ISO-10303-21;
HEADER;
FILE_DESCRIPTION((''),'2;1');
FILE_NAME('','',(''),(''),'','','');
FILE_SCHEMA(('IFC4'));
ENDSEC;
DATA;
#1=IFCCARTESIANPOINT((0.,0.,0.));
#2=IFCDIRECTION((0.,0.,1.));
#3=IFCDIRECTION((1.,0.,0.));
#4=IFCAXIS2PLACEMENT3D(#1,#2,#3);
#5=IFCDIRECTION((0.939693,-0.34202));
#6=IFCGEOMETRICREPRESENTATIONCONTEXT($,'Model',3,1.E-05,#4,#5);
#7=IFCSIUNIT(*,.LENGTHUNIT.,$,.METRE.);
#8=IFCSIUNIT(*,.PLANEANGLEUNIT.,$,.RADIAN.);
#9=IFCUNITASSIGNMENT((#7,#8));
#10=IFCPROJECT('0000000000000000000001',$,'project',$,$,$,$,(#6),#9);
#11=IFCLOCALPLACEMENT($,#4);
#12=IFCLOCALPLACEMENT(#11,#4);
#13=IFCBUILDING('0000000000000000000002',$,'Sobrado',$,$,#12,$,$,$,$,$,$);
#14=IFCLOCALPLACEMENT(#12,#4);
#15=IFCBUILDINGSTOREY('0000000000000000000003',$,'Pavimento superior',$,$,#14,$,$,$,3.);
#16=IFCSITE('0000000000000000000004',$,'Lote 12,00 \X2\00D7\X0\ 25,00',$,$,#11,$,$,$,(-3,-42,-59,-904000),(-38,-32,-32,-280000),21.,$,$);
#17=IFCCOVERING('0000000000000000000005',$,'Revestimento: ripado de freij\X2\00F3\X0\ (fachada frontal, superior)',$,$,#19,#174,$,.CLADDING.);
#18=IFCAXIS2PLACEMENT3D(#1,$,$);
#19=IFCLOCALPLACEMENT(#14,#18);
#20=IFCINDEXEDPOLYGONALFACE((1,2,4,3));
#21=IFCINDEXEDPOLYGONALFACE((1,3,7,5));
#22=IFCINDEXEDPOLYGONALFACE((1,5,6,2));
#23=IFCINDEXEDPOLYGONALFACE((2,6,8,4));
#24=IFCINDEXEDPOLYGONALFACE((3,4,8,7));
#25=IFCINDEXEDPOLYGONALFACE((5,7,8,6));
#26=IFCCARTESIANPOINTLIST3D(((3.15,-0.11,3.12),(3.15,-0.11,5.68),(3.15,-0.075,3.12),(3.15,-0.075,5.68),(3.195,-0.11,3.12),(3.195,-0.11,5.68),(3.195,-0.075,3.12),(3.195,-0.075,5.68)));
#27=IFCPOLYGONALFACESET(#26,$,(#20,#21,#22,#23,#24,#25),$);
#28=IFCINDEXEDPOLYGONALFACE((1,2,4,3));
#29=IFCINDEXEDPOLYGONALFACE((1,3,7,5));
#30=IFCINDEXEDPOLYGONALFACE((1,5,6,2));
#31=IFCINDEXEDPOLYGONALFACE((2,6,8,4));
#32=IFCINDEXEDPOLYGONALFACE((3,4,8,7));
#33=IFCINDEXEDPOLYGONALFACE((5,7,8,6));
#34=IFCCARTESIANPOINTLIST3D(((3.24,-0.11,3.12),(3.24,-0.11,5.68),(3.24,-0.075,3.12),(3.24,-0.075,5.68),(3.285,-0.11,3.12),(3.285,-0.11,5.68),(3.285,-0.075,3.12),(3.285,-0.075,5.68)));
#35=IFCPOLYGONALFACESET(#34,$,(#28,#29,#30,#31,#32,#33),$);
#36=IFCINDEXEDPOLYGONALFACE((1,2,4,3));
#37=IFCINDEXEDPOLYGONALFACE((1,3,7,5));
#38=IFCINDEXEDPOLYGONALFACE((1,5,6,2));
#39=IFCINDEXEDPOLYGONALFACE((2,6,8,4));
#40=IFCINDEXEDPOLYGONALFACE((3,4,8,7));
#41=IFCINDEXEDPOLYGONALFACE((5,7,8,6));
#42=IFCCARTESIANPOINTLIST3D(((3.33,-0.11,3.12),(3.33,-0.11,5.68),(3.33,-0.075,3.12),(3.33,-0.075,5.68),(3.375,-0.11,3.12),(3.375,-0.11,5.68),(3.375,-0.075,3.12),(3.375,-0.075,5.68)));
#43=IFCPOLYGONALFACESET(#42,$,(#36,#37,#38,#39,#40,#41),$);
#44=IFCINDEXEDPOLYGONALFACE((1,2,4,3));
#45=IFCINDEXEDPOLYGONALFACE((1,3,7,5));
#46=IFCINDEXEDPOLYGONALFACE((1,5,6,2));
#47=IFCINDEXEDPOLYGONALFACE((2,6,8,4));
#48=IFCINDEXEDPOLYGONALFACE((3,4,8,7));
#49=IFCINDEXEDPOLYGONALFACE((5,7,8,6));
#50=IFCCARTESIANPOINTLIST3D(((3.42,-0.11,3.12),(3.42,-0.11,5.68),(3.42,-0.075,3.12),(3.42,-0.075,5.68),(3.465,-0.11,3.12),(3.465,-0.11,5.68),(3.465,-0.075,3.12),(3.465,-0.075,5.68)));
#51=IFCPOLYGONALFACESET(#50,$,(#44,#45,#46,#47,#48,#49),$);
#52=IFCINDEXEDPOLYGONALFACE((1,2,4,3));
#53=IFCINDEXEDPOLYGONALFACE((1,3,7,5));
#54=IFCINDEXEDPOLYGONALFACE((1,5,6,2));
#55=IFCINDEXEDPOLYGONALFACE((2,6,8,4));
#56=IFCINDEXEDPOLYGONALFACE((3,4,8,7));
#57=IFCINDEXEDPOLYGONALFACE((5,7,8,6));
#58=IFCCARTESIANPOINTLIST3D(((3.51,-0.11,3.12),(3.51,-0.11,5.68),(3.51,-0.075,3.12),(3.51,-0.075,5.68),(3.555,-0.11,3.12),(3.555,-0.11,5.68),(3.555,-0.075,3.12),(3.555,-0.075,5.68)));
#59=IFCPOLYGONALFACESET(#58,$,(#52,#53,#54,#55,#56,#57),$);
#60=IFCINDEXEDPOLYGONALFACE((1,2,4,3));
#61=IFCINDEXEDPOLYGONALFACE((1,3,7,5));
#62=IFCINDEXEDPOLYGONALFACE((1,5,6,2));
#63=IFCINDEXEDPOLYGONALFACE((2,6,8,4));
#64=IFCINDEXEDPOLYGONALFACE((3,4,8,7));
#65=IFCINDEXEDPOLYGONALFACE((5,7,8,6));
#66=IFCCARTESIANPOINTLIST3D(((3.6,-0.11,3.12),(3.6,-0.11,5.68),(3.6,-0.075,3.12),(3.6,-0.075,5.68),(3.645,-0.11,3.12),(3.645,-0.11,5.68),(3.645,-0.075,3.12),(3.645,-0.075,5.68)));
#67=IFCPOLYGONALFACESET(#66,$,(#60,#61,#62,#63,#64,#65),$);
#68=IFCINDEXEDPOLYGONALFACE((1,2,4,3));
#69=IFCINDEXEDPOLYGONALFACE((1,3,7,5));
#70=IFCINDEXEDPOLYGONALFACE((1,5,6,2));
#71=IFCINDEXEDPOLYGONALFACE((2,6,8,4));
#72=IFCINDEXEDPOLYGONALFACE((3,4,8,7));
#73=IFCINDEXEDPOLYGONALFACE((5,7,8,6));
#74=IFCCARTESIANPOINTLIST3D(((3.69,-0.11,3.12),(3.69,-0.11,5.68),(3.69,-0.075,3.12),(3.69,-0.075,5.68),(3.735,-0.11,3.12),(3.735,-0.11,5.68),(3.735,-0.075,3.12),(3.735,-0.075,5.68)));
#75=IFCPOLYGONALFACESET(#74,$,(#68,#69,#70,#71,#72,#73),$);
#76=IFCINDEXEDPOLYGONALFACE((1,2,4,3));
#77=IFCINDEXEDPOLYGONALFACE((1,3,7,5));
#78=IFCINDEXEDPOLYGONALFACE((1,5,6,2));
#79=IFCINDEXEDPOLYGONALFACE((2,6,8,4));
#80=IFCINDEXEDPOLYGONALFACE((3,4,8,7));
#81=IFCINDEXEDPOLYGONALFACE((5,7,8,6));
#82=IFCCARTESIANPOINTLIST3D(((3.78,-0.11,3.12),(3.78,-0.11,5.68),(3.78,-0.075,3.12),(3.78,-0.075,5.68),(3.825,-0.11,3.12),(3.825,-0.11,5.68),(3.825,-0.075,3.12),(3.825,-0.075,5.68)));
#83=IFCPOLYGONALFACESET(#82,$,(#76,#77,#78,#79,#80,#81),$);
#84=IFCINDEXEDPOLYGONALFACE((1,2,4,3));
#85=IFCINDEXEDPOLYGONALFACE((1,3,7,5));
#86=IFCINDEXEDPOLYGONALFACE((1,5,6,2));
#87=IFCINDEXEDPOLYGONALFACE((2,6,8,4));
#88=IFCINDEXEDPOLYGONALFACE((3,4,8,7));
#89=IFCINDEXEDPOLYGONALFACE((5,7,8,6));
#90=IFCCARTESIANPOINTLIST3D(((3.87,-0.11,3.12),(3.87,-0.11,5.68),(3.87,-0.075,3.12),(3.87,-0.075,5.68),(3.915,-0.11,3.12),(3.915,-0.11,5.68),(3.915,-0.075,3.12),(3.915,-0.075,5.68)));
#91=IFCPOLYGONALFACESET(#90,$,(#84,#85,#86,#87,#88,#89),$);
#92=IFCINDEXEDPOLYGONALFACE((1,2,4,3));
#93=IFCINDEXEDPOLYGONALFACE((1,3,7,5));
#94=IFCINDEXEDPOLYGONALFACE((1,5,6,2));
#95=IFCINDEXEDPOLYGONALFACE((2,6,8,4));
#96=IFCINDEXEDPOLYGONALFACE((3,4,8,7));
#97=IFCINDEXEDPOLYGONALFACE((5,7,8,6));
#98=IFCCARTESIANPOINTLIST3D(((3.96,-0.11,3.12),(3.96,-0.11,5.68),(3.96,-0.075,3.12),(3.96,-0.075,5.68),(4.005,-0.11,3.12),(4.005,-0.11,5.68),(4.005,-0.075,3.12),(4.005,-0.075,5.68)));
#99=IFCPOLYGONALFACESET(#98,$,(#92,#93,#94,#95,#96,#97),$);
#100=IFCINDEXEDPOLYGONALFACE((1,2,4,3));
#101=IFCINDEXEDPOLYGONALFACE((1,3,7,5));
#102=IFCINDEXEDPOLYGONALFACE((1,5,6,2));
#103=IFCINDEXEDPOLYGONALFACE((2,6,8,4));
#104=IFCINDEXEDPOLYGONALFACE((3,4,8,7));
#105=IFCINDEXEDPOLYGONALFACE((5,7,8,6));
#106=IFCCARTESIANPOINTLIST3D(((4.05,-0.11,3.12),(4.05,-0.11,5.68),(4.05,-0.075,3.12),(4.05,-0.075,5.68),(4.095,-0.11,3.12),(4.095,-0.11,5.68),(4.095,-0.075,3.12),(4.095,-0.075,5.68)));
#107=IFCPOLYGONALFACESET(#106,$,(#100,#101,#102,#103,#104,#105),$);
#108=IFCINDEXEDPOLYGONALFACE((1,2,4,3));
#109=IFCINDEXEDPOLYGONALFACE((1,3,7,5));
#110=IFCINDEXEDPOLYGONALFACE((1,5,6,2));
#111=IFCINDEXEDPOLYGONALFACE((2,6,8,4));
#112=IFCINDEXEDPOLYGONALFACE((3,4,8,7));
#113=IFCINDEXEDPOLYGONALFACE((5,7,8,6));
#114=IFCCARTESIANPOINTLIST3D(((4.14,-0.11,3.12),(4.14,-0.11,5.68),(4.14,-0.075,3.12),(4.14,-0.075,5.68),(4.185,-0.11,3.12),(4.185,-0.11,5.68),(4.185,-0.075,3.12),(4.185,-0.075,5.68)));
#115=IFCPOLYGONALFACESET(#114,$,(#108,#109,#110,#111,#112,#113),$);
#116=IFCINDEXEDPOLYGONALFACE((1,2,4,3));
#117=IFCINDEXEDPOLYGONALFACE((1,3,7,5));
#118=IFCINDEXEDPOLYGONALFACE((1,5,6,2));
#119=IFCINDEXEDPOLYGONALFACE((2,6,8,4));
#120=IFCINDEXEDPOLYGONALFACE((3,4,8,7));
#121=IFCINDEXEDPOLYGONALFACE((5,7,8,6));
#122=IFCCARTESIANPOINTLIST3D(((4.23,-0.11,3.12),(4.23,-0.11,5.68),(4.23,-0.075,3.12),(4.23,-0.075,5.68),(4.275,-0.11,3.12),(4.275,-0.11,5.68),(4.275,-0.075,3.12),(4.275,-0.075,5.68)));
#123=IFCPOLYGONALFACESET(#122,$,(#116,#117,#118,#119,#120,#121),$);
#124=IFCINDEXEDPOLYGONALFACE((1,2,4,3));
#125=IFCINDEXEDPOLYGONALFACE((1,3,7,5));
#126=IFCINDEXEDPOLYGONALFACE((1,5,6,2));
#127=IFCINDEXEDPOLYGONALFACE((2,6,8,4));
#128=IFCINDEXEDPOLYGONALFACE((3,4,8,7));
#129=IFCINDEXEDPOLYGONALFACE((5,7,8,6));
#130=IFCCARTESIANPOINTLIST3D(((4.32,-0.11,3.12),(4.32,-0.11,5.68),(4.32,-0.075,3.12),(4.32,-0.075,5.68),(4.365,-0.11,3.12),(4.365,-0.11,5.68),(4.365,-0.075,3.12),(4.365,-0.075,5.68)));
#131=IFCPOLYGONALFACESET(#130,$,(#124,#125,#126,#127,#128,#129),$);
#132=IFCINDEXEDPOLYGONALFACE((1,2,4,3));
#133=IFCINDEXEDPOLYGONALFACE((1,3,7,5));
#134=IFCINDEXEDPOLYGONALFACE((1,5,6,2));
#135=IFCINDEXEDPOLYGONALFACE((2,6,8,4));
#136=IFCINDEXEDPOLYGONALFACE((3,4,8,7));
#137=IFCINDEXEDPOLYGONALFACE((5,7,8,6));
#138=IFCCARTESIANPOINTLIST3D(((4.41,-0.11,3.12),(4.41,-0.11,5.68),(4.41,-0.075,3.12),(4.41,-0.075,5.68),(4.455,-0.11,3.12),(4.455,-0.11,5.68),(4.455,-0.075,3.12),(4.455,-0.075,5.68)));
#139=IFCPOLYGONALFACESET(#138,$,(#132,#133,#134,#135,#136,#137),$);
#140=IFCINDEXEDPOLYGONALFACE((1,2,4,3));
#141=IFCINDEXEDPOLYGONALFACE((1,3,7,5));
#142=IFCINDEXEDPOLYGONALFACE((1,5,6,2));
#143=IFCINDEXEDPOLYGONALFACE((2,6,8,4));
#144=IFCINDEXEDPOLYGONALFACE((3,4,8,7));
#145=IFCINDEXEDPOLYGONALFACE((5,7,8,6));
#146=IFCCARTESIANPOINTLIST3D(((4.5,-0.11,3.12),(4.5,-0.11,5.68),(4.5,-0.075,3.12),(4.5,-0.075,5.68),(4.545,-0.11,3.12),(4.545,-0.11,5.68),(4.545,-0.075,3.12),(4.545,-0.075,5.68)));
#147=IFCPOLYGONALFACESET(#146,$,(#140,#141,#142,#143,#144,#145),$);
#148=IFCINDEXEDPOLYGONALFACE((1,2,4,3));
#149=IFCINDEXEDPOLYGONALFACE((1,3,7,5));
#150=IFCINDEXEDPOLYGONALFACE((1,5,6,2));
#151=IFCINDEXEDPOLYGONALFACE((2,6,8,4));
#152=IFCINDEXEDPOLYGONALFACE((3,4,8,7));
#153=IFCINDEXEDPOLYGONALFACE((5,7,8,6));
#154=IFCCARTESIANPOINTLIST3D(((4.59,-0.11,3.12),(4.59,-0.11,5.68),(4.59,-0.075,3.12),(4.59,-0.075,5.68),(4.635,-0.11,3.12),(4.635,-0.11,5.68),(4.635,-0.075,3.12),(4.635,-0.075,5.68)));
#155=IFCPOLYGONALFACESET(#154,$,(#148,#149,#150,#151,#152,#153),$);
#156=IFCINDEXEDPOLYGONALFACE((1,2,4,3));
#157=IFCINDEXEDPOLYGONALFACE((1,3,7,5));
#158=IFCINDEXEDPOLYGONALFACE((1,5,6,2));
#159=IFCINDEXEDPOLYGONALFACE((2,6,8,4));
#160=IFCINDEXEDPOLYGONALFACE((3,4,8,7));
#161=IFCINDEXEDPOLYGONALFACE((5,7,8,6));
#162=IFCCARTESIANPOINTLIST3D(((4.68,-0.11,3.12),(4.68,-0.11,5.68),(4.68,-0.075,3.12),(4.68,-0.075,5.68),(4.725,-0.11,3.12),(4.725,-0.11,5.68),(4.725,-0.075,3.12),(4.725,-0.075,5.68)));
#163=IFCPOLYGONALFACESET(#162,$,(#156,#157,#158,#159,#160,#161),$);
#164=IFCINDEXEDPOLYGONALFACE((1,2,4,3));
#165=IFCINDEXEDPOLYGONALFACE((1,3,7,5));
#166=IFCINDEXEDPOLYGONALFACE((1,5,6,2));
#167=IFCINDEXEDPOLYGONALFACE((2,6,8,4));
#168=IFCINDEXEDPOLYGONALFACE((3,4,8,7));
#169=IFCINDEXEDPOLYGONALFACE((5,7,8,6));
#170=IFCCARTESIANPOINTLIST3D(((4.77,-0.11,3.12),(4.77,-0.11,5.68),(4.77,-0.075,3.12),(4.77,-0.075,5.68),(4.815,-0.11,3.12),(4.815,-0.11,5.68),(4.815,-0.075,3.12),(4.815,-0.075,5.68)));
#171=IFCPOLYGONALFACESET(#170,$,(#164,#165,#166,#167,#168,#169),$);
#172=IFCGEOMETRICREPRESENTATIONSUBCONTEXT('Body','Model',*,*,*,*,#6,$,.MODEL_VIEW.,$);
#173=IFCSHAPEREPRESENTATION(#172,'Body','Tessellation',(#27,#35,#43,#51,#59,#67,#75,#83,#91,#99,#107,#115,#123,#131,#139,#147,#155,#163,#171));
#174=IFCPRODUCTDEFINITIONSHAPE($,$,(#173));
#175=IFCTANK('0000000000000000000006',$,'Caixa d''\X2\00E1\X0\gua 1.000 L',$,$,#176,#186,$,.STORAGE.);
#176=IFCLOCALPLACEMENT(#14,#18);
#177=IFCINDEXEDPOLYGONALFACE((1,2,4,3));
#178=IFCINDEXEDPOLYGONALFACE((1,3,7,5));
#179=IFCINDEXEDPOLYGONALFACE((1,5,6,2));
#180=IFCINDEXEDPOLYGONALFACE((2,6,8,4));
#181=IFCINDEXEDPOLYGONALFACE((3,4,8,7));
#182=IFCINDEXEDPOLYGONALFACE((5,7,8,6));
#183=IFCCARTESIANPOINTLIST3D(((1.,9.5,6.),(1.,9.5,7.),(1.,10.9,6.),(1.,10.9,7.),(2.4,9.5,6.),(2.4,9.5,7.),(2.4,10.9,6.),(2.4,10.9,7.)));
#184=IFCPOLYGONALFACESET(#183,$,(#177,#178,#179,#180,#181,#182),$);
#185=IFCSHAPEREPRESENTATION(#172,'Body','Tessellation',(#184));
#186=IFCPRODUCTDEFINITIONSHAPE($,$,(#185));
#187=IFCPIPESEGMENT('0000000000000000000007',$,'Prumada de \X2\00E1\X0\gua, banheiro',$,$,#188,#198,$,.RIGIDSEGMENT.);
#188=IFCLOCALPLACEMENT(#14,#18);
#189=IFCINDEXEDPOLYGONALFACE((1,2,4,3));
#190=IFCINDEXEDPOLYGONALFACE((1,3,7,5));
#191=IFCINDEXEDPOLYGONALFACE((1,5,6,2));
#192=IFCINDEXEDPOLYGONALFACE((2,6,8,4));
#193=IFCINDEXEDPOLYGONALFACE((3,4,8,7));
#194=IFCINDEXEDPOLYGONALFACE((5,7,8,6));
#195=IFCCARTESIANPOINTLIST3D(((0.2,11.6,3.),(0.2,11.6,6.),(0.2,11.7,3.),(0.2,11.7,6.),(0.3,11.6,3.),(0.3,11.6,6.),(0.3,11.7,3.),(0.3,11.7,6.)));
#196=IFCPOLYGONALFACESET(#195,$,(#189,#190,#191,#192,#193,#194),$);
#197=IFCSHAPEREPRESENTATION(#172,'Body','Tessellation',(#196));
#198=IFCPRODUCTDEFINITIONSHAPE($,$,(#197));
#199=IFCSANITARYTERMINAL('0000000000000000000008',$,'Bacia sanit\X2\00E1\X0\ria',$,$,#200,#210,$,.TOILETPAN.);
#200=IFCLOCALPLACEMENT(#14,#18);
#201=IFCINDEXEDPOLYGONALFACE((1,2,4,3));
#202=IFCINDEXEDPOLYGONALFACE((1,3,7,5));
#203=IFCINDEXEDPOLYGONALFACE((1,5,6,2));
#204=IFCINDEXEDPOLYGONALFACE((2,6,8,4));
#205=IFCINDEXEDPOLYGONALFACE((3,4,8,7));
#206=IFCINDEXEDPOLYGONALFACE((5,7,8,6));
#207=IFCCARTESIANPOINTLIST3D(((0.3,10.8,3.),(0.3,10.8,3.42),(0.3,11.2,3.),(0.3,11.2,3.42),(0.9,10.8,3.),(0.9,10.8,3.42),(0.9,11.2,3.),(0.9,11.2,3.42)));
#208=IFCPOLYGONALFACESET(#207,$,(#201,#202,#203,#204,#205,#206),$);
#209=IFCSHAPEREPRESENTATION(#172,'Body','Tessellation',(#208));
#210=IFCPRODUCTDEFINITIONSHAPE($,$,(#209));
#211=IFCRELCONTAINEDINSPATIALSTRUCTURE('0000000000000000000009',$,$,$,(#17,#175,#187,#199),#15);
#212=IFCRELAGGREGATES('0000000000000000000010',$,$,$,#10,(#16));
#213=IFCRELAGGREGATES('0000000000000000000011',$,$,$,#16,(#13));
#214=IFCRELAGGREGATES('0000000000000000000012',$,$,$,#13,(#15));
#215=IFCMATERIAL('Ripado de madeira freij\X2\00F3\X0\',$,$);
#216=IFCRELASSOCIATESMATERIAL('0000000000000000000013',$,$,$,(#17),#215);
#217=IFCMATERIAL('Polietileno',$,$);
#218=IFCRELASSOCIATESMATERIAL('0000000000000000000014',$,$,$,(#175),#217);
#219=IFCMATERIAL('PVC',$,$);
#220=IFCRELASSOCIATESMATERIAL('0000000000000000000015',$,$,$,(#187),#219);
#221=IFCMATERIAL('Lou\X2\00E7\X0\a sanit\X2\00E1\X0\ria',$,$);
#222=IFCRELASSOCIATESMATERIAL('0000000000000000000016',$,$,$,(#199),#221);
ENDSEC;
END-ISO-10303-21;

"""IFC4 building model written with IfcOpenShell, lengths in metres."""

from ifc_helpers import new_model, si_unit, direction, frame, origin_with_axes, place, context, subcontext, project, spatial, line, indexed_curve, outline, extrude, material, element, save


model = new_model("IFC4")

# Units and contexts
model_context = context("Model", 3, precision=1e-05, world=origin_with_axes(), true_north=direction((0.939693, -0.34202)))
body_context = subcontext(model_context, "Body", "Model", "MODEL_VIEW")
ifc_project = project(units=[si_unit("LENGTHUNIT", "METRE"), si_unit("PLANEANGLEUNIT", "RADIAN")], contexts=[model_context])

# Site, building, storey
site_placement = place(None, origin_with_axes())
site = spatial("IfcSite", under=ifc_project, at=site_placement, Name="Lote 12,00 × 25,00", RefLatitude=(-3, -42, -59, -904000), RefLongitude=(-38, -32, -32, -280000), RefElevation=21.0)
building_placement = place(site_placement, origin_with_axes())
building = spatial("IfcBuilding", under=site, at=building_placement, Name="Sobrado")
storey_placement = place(building_placement, origin_with_axes())
storey = spatial("IfcBuildingStorey", under=building, at=storey_placement, Name="Pavimento superior", Elevation=3.0)

# Covering
ifc_material_1 = material(Name="Ripado de madeira freijó")
covering_1_placement = place(storey_placement, origin_with_axes())
element("IfcCovering", 1, at=covering_1_placement, inside=storey, material=ifc_material_1, Name="Revestimento: ripado de freijó (fachada frontal, superior)", PredefinedType="CLADDING", context=body_context, shape_type="SweptSolid", body=[
    extrude(outline(indexed_curve([(3.15, -0.11), (3.195, -0.11), (3.195, -0.075), (3.15, -0.075)], segments=[line(1, 2, 3, 4, 1)])), frame((0.0, 0.0, 3.12), z_axis=(0.0, 0.0, 1.0), x_axis=(1.0, 0.0, 0.0)), (0.0, 0.0, 1.0), 2.56),
    extrude(outline(indexed_curve([(3.24, -0.11), (3.285, -0.11), (3.285, -0.075), (3.24, -0.075)], segments=[line(1, 2, 3, 4, 1)])), frame((0.0, 0.0, 3.12), z_axis=(0.0, 0.0, 1.0), x_axis=(1.0, 0.0, 0.0)), (0.0, 0.0, 1.0), 2.56),
    extrude(outline(indexed_curve([(3.33, -0.11), (3.375, -0.11), (3.375, -0.075), (3.33, -0.075)], segments=[line(1, 2, 3, 4, 1)])), frame((0.0, 0.0, 3.12), z_axis=(0.0, 0.0, 1.0), x_axis=(1.0, 0.0, 0.0)), (0.0, 0.0, 1.0), 2.56),
    extrude(outline(indexed_curve([(3.42, -0.11), (3.465, -0.11), (3.465, -0.075), (3.42, -0.075)], segments=[line(1, 2, 3, 4, 1)])), frame((0.0, 0.0, 3.12), z_axis=(0.0, 0.0, 1.0), x_axis=(1.0, 0.0, 0.0)), (0.0, 0.0, 1.0), 2.56),
    extrude(outline(indexed_curve([(3.51, -0.11), (3.555, -0.11), (3.555, -0.075), (3.51, -0.075)], segments=[line(1, 2, 3, 4, 1)])), frame((0.0, 0.0, 3.12), z_axis=(0.0, 0.0, 1.0), x_axis=(1.0, 0.0, 0.0)), (0.0, 0.0, 1.0), 2.56),
    extrude(outline(indexed_curve([(3.6, -0.11), (3.645, -0.11), (3.645, -0.075), (3.6, -0.075)], segments=[line(1, 2, 3, 4, 1)])), frame((0.0, 0.0, 3.12), z_axis=(0.0, 0.0, 1.0), x_axis=(1.0, 0.0, 0.0)), (0.0, 0.0, 1.0), 2.56),
    extrude(outline(indexed_curve([(3.69, -0.11), (3.735, -0.11), (3.735, -0.075), (3.69, -0.075)], segments=[line(1, 2, 3, 4, 1)])), frame((0.0, 0.0, 3.12), z_axis=(0.0, 0.0, 1.0), x_axis=(1.0, 0.0, 0.0)), (0.0, 0.0, 1.0), 2.56),
    extrude(outline(indexed_curve([(3.78, -0.11), (3.825, -0.11), (3.825, -0.075), (3.78, -0.075)], segments=[line(1, 2, 3, 4, 1)])), frame((0.0, 0.0, 3.12), z_axis=(0.0, 0.0, 1.0), x_axis=(1.0, 0.0, 0.0)), (0.0, 0.0, 1.0), 2.56),
    extrude(outline(indexed_curve([(3.87, -0.11), (3.915, -0.11), (3.915, -0.075), (3.87, -0.075)], segments=[line(1, 2, 3, 4, 1)])), frame((0.0, 0.0, 3.12), z_axis=(0.0, 0.0, 1.0), x_axis=(1.0, 0.0, 0.0)), (0.0, 0.0, 1.0), 2.56),
    extrude(outline(indexed_curve([(3.96, -0.11), (4.005, -0.11), (4.005, -0.075), (3.96, -0.075)], segments=[line(1, 2, 3, 4, 1)])), frame((0.0, 0.0, 3.12), z_axis=(0.0, 0.0, 1.0), x_axis=(1.0, 0.0, 0.0)), (0.0, 0.0, 1.0), 2.56),
    extrude(outline(indexed_curve([(4.05, -0.11), (4.095, -0.11), (4.095, -0.075), (4.05, -0.075)], segments=[line(1, 2, 3, 4, 1)])), frame((0.0, 0.0, 3.12), z_axis=(0.0, 0.0, 1.0), x_axis=(1.0, 0.0, 0.0)), (0.0, 0.0, 1.0), 2.56),
    extrude(outline(indexed_curve([(4.14, -0.11), (4.185, -0.11), (4.185, -0.075), (4.14, -0.075)], segments=[line(1, 2, 3, 4, 1)])), frame((0.0, 0.0, 3.12), z_axis=(0.0, 0.0, 1.0), x_axis=(1.0, 0.0, 0.0)), (0.0, 0.0, 1.0), 2.56),
    extrude(outline(indexed_curve([(4.23, -0.11), (4.275, -0.11), (4.275, -0.075), (4.23, -0.075)], segments=[line(1, 2, 3, 4, 1)])), frame((0.0, 0.0, 3.12), z_axis=(0.0, 0.0, 1.0), x_axis=(1.0, 0.0, 0.0)), (0.0, 0.0, 1.0), 2.56),
    extrude(outline(indexed_curve([(4.32, -0.11), (4.365, -0.11), (4.365, -0.075), (4.32, -0.075)], segments=[line(1, 2, 3, 4, 1)])), frame((0.0, 0.0, 3.12), z_axis=(0.0, 0.0, 1.0), x_axis=(1.0, 0.0, 0.0)), (0.0, 0.0, 1.0), 2.56),
    extrude(outline(indexed_curve([(4.41, -0.11), (4.455, -0.11), (4.455, -0.075), (4.41, -0.075)], segments=[line(1, 2, 3, 4, 1)])), frame((0.0, 0.0, 3.12), z_axis=(0.0, 0.0, 1.0), x_axis=(1.0, 0.0, 0.0)), (0.0, 0.0, 1.0), 2.56),
    extrude(outline(indexed_curve([(4.5, -0.11), (4.545, -0.11), (4.545, -0.075), (4.5, -0.075)], segments=[line(1, 2, 3, 4, 1)])), frame((0.0, 0.0, 3.12), z_axis=(0.0, 0.0, 1.0), x_axis=(1.0, 0.0, 0.0)), (0.0, 0.0, 1.0), 2.56),
    extrude(outline(indexed_curve([(4.59, -0.11), (4.635, -0.11), (4.635, -0.075), (4.59, -0.075)], segments=[line(1, 2, 3, 4, 1)])), frame((0.0, 0.0, 3.12), z_axis=(0.0, 0.0, 1.0), x_axis=(1.0, 0.0, 0.0)), (0.0, 0.0, 1.0), 2.56),
    extrude(outline(indexed_curve([(4.68, -0.11), (4.725, -0.11), (4.725, -0.075), (4.68, -0.075)], segments=[line(1, 2, 3, 4, 1)])), frame((0.0, 0.0, 3.12), z_axis=(0.0, 0.0, 1.0), x_axis=(1.0, 0.0, 0.0)), (0.0, 0.0, 1.0), 2.56),
    extrude(outline(indexed_curve([(4.77, -0.11), (4.815, -0.11), (4.815, -0.075), (4.77, -0.075)], segments=[line(1, 2, 3, 4, 1)])), frame((0.0, 0.0, 3.12), z_axis=(0.0, 0.0, 1.0), x_axis=(1.0, 0.0, 0.0)), (0.0, 0.0, 1.0), 2.56),
])

# Tank
ifc_material_2 = material(Name="Polietileno")
tank_placement = place(storey_placement, origin_with_axes())
element("IfcTank", 2, at=tank_placement, inside=storey, material=ifc_material_2, Name="Caixa d'água 1.000 L", PredefinedType="STORAGE", context=body_context, shape_type="SweptSolid", body=[
    extrude(outline(indexed_curve([(1.0, 9.5), (2.4, 9.5), (2.4, 10.9), (1.0, 10.9)], segments=[line(1, 2, 3, 4, 1)])), frame((0.0, 0.0, 6.0), z_axis=(0.0, 0.0, 1.0), x_axis=(1.0, 0.0, 0.0)), (0.0, 0.0, 1.0), 1.0),
])

# Pipe segment
ifc_material_3 = material(Name="PVC")
pipe_segment_placement = place(storey_placement, origin_with_axes())
element("IfcPipeSegment", 3, at=pipe_segment_placement, inside=storey, material=ifc_material_3, Name="Prumada de água, banheiro", PredefinedType="RIGIDSEGMENT", context=body_context, shape_type="SweptSolid", body=[
    extrude(outline(indexed_curve([(0.2, 11.6), (0.3, 11.6), (0.3, 11.7), (0.2, 11.7)], segments=[line(1, 2, 3, 4, 1)])), frame((0.0, 0.0, 3.0), z_axis=(0.0, 0.0, 1.0), x_axis=(1.0, 0.0, 0.0)), (0.0, 0.0, 1.0), 3.0),
])

# Sanitary terminal
ifc_material_4 = material(Name="Louça sanitária")
sanitary_terminal_1_placement = place(storey_placement, origin_with_axes())
element("IfcSanitaryTerminal", 4, at=sanitary_terminal_1_placement, inside=storey, material=ifc_material_4, Name="Bacia sanitária", PredefinedType="TOILETPAN", context=body_context, shape_type="SweptSolid", body=[
    extrude(outline(indexed_curve([(0.3, 10.8), (0.9, 10.8), (0.9, 11.2), (0.3, 11.2)], segments=[line(1, 2, 3, 4, 1)])), frame((0.0, 0.0, 3.0), z_axis=(0.0, 0.0, 1.0), x_axis=(1.0, 0.0, 0.0)), (0.0, 0.0, 1.0), 0.42),
])

save(model, "model.ifc")
